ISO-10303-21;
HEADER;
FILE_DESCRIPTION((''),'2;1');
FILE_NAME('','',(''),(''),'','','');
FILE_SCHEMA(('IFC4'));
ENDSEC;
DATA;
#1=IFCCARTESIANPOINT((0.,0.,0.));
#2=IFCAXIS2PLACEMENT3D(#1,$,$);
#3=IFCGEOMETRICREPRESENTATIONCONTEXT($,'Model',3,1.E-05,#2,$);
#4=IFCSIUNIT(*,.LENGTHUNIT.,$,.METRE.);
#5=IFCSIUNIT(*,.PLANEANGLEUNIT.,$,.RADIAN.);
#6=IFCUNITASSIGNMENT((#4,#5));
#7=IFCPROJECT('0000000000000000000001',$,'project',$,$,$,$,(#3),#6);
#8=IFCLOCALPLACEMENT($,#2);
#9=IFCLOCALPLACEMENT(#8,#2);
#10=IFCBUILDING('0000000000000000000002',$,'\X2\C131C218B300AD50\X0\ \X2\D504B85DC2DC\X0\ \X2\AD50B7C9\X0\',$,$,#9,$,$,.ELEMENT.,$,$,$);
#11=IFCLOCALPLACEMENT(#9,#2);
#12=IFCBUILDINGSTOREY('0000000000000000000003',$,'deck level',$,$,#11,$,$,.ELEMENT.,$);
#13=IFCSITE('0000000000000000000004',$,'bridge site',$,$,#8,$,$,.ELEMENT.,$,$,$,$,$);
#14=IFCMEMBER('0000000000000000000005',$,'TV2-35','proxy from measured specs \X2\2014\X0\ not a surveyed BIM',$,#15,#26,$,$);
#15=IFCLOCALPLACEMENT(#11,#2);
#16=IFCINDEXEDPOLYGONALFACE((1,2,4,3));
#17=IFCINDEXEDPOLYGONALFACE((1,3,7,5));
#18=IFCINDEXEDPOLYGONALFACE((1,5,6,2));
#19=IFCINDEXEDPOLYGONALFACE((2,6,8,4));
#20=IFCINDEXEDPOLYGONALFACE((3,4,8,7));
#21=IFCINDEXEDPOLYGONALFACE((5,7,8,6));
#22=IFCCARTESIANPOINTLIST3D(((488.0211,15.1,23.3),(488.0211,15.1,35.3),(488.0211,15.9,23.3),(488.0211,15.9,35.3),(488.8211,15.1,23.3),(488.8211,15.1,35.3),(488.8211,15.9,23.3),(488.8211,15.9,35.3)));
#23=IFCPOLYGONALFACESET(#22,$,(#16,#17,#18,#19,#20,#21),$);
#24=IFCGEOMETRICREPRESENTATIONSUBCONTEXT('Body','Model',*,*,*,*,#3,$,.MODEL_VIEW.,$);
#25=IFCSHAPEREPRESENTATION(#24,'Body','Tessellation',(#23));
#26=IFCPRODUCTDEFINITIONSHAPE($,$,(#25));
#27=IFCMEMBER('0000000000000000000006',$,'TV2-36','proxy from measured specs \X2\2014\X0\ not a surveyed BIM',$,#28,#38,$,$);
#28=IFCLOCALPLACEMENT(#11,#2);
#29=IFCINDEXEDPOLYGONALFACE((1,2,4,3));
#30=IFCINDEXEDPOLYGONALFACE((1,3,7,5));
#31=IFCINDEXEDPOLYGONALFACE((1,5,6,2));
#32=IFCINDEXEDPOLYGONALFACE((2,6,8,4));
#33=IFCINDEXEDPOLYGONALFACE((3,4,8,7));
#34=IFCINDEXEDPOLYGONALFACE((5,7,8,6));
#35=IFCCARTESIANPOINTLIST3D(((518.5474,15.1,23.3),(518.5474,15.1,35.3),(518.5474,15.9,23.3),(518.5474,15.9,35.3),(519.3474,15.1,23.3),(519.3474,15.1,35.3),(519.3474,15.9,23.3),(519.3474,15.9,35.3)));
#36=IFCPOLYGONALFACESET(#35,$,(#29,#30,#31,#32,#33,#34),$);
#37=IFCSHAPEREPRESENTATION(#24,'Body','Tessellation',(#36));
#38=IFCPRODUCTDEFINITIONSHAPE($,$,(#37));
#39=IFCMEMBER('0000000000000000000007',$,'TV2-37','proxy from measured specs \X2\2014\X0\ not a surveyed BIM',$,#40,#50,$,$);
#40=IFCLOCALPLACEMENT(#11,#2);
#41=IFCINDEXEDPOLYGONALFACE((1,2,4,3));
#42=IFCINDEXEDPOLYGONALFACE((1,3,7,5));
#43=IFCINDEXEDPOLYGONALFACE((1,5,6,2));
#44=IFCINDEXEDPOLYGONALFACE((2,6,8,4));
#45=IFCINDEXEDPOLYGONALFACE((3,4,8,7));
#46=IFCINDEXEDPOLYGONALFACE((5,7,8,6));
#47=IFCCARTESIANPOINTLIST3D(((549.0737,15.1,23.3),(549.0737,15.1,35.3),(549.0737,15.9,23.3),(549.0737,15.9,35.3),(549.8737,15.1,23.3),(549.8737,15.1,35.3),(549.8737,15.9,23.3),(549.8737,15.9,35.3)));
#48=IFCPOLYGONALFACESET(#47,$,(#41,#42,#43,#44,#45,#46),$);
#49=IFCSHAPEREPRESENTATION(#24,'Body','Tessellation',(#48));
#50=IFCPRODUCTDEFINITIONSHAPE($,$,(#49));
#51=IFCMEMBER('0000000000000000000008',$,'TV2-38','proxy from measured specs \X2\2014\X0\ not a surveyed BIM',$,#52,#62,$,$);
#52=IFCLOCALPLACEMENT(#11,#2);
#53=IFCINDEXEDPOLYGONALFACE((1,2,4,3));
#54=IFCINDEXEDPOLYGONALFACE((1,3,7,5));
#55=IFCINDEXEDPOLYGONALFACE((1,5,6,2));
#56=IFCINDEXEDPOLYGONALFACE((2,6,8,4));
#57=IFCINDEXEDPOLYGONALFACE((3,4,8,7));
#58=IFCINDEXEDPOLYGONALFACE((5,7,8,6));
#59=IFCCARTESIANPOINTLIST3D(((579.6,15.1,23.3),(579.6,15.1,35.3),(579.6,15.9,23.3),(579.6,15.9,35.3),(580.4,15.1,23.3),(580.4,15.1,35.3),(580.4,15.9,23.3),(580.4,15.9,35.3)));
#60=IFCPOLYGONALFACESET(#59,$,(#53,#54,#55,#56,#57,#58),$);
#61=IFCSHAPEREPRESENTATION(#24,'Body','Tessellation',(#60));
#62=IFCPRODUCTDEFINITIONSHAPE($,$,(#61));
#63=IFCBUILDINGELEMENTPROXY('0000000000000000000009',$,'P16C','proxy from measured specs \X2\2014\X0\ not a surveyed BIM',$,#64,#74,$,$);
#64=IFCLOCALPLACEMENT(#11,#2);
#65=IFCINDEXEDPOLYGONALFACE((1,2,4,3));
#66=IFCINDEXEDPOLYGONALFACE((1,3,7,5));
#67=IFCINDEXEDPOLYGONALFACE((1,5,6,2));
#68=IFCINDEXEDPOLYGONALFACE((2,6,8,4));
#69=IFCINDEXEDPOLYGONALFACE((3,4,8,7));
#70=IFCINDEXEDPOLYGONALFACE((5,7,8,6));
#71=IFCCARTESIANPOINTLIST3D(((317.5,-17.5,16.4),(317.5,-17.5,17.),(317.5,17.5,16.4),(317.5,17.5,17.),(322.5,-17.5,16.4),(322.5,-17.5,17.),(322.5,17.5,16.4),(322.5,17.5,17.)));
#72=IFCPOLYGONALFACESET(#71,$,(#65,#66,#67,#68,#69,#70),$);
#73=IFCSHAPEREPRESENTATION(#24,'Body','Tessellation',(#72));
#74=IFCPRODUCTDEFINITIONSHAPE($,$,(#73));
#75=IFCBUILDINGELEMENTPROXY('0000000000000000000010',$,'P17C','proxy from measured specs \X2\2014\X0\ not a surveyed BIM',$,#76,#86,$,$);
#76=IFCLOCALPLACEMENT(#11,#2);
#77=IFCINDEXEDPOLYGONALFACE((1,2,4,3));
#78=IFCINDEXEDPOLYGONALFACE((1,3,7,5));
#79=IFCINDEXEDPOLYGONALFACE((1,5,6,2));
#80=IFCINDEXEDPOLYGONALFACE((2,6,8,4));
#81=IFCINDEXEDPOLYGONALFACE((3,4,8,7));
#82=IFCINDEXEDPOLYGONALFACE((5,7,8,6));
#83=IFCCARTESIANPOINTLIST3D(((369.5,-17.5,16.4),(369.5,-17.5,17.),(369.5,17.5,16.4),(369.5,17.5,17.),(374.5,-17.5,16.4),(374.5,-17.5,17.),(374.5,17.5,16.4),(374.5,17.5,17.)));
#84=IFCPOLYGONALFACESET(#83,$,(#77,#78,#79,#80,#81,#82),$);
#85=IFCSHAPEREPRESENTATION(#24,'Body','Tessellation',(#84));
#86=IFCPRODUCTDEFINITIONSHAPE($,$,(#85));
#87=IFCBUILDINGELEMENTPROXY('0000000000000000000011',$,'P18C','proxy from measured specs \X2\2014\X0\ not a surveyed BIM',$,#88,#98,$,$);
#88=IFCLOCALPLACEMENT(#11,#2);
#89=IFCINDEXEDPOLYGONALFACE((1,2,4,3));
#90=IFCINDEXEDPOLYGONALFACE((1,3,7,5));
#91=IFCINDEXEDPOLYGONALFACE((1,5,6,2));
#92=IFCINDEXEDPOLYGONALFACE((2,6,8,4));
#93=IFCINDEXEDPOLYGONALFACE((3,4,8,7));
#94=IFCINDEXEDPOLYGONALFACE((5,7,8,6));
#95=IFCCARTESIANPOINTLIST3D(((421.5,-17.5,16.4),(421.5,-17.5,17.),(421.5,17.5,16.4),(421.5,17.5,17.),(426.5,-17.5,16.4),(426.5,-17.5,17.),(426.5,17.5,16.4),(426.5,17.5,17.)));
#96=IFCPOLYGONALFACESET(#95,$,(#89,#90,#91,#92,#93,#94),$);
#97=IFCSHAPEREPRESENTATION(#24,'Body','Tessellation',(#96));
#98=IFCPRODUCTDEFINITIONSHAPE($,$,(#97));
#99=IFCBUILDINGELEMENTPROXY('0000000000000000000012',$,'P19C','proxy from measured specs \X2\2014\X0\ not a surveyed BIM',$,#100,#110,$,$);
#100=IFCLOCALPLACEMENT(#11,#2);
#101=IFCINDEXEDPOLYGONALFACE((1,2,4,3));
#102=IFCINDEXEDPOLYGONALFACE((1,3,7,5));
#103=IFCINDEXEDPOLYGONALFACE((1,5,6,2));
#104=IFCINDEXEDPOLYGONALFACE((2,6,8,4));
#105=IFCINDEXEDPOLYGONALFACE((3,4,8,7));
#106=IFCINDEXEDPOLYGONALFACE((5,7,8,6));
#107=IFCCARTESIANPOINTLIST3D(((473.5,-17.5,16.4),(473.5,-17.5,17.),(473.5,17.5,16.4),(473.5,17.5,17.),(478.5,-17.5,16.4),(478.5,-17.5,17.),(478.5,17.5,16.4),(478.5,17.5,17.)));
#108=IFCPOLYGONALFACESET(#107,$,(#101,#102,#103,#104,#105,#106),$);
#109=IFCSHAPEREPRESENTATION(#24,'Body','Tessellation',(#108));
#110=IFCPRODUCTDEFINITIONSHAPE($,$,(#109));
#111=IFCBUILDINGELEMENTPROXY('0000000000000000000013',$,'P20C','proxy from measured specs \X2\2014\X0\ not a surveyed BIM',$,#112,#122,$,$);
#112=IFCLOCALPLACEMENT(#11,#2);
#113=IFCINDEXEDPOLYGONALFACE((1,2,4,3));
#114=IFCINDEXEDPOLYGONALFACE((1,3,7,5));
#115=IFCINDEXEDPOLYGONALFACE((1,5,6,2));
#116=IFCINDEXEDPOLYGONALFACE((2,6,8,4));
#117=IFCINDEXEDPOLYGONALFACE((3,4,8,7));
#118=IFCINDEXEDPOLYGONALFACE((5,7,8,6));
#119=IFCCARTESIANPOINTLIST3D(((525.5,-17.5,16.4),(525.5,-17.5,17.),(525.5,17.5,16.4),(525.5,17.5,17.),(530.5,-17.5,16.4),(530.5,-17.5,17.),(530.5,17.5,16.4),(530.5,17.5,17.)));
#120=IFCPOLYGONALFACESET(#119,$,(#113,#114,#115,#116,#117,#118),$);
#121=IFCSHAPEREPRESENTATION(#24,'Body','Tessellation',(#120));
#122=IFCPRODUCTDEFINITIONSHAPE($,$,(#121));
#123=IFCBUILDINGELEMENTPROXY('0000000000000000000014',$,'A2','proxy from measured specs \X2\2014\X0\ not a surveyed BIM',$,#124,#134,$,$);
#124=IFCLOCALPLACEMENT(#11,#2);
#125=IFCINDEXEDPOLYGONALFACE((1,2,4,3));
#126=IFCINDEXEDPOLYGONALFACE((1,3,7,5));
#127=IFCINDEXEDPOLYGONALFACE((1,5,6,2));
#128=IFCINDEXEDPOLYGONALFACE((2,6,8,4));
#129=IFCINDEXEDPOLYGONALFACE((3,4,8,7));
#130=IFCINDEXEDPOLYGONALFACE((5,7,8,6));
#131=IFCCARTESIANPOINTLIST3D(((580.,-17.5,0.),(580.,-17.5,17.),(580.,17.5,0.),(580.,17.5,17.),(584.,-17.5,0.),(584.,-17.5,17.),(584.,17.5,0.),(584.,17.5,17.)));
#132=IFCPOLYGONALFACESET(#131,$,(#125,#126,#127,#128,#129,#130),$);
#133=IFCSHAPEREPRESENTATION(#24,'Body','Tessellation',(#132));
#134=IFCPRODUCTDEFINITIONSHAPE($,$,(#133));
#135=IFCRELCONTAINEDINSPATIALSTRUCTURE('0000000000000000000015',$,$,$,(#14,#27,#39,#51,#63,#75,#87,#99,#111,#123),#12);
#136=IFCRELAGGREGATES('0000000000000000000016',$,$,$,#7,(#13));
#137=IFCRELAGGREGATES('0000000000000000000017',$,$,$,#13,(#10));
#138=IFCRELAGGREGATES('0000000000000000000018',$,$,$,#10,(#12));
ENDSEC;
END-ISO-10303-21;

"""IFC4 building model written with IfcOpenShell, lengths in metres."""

from ifc_helpers import new_model, si_unit, frame, origin, origin_2d, place, context, subcontext, project, spatial, rectangle, extrude, element, save


model = new_model("IFC4")

# Units and contexts
model_context = context("Model", 3, precision=1e-05, world=origin())
body_context = subcontext(model_context, "Body", "Model", "MODEL_VIEW")
ifc_project = project(units=[si_unit("LENGTHUNIT", "METRE"), si_unit("PLANEANGLEUNIT", "RADIAN")], contexts=[model_context])

# Site, building, storey
site_placement = place(None, origin())
site = spatial("IfcSite", under=ifc_project, at=site_placement, Name="bridge site", CompositionType="ELEMENT")
building_placement = place(site_placement, origin())
building = spatial("IfcBuilding", under=site, at=building_placement, Name="성수대교 프록시 교량", CompositionType="ELEMENT")
storey_placement = place(building_placement, origin())
storey = spatial("IfcBuildingStorey", under=building, at=storey_placement, Name="deck level", CompositionType="ELEMENT")

# Members
for number, where, name in (
    (1, (488.4211, 15.5, 23.3), "TV2-35"),
    (2, (518.9474, 15.5, 23.3), "TV2-36"),
    (3, (549.4737, 15.5, 23.3), "TV2-37"),
    (4, (580.0, 15.5, 23.3), "TV2-38"),
):
    element("IfcMember", number, at=place(storey_placement, frame(where)), inside=storey, Name=name, Description="proxy from measured specs — not a surveyed BIM", context=body_context, shape_type="SweptSolid", body=[
        extrude(rectangle(XDim=0.8, YDim=0.8, at=origin_2d()), origin(), (0.0, 0.0, 1.0), 12.0),
    ])

# Building element proxies
for number, where, name in (
    (5, (320.0, 0.0, 16.4), "P16C"),
    (6, (372.0, 0.0, 16.4), "P17C"),
    (7, (424.0, 0.0, 16.4), "P18C"),
    (8, (476.0, 0.0, 16.4), "P19C"),
    (9, (528.0, 0.0, 16.4), "P20C"),
):
    element("IfcBuildingElementProxy", number, at=place(storey_placement, frame(where)), inside=storey, Name=name, Description="proxy from measured specs — not a surveyed BIM", context=body_context, shape_type="SweptSolid", body=[
        extrude(rectangle(XDim=5.0, YDim=35.0, at=origin_2d()), origin(), (0.0, 0.0, 1.0), 0.6),
    ])
proxy_placement = place(storey_placement, frame((582.0, 0.0, 0.0)))
element("IfcBuildingElementProxy", 10, at=proxy_placement, inside=storey, Name="A2", Description="proxy from measured specs — not a surveyed BIM", context=body_context, shape_type="SweptSolid", body=[
    extrude(rectangle(XDim=4.0, YDim=35.0, at=origin_2d()), origin(), (0.0, 0.0, 1.0), 17.0),
])

save(model, "model.ifc")
